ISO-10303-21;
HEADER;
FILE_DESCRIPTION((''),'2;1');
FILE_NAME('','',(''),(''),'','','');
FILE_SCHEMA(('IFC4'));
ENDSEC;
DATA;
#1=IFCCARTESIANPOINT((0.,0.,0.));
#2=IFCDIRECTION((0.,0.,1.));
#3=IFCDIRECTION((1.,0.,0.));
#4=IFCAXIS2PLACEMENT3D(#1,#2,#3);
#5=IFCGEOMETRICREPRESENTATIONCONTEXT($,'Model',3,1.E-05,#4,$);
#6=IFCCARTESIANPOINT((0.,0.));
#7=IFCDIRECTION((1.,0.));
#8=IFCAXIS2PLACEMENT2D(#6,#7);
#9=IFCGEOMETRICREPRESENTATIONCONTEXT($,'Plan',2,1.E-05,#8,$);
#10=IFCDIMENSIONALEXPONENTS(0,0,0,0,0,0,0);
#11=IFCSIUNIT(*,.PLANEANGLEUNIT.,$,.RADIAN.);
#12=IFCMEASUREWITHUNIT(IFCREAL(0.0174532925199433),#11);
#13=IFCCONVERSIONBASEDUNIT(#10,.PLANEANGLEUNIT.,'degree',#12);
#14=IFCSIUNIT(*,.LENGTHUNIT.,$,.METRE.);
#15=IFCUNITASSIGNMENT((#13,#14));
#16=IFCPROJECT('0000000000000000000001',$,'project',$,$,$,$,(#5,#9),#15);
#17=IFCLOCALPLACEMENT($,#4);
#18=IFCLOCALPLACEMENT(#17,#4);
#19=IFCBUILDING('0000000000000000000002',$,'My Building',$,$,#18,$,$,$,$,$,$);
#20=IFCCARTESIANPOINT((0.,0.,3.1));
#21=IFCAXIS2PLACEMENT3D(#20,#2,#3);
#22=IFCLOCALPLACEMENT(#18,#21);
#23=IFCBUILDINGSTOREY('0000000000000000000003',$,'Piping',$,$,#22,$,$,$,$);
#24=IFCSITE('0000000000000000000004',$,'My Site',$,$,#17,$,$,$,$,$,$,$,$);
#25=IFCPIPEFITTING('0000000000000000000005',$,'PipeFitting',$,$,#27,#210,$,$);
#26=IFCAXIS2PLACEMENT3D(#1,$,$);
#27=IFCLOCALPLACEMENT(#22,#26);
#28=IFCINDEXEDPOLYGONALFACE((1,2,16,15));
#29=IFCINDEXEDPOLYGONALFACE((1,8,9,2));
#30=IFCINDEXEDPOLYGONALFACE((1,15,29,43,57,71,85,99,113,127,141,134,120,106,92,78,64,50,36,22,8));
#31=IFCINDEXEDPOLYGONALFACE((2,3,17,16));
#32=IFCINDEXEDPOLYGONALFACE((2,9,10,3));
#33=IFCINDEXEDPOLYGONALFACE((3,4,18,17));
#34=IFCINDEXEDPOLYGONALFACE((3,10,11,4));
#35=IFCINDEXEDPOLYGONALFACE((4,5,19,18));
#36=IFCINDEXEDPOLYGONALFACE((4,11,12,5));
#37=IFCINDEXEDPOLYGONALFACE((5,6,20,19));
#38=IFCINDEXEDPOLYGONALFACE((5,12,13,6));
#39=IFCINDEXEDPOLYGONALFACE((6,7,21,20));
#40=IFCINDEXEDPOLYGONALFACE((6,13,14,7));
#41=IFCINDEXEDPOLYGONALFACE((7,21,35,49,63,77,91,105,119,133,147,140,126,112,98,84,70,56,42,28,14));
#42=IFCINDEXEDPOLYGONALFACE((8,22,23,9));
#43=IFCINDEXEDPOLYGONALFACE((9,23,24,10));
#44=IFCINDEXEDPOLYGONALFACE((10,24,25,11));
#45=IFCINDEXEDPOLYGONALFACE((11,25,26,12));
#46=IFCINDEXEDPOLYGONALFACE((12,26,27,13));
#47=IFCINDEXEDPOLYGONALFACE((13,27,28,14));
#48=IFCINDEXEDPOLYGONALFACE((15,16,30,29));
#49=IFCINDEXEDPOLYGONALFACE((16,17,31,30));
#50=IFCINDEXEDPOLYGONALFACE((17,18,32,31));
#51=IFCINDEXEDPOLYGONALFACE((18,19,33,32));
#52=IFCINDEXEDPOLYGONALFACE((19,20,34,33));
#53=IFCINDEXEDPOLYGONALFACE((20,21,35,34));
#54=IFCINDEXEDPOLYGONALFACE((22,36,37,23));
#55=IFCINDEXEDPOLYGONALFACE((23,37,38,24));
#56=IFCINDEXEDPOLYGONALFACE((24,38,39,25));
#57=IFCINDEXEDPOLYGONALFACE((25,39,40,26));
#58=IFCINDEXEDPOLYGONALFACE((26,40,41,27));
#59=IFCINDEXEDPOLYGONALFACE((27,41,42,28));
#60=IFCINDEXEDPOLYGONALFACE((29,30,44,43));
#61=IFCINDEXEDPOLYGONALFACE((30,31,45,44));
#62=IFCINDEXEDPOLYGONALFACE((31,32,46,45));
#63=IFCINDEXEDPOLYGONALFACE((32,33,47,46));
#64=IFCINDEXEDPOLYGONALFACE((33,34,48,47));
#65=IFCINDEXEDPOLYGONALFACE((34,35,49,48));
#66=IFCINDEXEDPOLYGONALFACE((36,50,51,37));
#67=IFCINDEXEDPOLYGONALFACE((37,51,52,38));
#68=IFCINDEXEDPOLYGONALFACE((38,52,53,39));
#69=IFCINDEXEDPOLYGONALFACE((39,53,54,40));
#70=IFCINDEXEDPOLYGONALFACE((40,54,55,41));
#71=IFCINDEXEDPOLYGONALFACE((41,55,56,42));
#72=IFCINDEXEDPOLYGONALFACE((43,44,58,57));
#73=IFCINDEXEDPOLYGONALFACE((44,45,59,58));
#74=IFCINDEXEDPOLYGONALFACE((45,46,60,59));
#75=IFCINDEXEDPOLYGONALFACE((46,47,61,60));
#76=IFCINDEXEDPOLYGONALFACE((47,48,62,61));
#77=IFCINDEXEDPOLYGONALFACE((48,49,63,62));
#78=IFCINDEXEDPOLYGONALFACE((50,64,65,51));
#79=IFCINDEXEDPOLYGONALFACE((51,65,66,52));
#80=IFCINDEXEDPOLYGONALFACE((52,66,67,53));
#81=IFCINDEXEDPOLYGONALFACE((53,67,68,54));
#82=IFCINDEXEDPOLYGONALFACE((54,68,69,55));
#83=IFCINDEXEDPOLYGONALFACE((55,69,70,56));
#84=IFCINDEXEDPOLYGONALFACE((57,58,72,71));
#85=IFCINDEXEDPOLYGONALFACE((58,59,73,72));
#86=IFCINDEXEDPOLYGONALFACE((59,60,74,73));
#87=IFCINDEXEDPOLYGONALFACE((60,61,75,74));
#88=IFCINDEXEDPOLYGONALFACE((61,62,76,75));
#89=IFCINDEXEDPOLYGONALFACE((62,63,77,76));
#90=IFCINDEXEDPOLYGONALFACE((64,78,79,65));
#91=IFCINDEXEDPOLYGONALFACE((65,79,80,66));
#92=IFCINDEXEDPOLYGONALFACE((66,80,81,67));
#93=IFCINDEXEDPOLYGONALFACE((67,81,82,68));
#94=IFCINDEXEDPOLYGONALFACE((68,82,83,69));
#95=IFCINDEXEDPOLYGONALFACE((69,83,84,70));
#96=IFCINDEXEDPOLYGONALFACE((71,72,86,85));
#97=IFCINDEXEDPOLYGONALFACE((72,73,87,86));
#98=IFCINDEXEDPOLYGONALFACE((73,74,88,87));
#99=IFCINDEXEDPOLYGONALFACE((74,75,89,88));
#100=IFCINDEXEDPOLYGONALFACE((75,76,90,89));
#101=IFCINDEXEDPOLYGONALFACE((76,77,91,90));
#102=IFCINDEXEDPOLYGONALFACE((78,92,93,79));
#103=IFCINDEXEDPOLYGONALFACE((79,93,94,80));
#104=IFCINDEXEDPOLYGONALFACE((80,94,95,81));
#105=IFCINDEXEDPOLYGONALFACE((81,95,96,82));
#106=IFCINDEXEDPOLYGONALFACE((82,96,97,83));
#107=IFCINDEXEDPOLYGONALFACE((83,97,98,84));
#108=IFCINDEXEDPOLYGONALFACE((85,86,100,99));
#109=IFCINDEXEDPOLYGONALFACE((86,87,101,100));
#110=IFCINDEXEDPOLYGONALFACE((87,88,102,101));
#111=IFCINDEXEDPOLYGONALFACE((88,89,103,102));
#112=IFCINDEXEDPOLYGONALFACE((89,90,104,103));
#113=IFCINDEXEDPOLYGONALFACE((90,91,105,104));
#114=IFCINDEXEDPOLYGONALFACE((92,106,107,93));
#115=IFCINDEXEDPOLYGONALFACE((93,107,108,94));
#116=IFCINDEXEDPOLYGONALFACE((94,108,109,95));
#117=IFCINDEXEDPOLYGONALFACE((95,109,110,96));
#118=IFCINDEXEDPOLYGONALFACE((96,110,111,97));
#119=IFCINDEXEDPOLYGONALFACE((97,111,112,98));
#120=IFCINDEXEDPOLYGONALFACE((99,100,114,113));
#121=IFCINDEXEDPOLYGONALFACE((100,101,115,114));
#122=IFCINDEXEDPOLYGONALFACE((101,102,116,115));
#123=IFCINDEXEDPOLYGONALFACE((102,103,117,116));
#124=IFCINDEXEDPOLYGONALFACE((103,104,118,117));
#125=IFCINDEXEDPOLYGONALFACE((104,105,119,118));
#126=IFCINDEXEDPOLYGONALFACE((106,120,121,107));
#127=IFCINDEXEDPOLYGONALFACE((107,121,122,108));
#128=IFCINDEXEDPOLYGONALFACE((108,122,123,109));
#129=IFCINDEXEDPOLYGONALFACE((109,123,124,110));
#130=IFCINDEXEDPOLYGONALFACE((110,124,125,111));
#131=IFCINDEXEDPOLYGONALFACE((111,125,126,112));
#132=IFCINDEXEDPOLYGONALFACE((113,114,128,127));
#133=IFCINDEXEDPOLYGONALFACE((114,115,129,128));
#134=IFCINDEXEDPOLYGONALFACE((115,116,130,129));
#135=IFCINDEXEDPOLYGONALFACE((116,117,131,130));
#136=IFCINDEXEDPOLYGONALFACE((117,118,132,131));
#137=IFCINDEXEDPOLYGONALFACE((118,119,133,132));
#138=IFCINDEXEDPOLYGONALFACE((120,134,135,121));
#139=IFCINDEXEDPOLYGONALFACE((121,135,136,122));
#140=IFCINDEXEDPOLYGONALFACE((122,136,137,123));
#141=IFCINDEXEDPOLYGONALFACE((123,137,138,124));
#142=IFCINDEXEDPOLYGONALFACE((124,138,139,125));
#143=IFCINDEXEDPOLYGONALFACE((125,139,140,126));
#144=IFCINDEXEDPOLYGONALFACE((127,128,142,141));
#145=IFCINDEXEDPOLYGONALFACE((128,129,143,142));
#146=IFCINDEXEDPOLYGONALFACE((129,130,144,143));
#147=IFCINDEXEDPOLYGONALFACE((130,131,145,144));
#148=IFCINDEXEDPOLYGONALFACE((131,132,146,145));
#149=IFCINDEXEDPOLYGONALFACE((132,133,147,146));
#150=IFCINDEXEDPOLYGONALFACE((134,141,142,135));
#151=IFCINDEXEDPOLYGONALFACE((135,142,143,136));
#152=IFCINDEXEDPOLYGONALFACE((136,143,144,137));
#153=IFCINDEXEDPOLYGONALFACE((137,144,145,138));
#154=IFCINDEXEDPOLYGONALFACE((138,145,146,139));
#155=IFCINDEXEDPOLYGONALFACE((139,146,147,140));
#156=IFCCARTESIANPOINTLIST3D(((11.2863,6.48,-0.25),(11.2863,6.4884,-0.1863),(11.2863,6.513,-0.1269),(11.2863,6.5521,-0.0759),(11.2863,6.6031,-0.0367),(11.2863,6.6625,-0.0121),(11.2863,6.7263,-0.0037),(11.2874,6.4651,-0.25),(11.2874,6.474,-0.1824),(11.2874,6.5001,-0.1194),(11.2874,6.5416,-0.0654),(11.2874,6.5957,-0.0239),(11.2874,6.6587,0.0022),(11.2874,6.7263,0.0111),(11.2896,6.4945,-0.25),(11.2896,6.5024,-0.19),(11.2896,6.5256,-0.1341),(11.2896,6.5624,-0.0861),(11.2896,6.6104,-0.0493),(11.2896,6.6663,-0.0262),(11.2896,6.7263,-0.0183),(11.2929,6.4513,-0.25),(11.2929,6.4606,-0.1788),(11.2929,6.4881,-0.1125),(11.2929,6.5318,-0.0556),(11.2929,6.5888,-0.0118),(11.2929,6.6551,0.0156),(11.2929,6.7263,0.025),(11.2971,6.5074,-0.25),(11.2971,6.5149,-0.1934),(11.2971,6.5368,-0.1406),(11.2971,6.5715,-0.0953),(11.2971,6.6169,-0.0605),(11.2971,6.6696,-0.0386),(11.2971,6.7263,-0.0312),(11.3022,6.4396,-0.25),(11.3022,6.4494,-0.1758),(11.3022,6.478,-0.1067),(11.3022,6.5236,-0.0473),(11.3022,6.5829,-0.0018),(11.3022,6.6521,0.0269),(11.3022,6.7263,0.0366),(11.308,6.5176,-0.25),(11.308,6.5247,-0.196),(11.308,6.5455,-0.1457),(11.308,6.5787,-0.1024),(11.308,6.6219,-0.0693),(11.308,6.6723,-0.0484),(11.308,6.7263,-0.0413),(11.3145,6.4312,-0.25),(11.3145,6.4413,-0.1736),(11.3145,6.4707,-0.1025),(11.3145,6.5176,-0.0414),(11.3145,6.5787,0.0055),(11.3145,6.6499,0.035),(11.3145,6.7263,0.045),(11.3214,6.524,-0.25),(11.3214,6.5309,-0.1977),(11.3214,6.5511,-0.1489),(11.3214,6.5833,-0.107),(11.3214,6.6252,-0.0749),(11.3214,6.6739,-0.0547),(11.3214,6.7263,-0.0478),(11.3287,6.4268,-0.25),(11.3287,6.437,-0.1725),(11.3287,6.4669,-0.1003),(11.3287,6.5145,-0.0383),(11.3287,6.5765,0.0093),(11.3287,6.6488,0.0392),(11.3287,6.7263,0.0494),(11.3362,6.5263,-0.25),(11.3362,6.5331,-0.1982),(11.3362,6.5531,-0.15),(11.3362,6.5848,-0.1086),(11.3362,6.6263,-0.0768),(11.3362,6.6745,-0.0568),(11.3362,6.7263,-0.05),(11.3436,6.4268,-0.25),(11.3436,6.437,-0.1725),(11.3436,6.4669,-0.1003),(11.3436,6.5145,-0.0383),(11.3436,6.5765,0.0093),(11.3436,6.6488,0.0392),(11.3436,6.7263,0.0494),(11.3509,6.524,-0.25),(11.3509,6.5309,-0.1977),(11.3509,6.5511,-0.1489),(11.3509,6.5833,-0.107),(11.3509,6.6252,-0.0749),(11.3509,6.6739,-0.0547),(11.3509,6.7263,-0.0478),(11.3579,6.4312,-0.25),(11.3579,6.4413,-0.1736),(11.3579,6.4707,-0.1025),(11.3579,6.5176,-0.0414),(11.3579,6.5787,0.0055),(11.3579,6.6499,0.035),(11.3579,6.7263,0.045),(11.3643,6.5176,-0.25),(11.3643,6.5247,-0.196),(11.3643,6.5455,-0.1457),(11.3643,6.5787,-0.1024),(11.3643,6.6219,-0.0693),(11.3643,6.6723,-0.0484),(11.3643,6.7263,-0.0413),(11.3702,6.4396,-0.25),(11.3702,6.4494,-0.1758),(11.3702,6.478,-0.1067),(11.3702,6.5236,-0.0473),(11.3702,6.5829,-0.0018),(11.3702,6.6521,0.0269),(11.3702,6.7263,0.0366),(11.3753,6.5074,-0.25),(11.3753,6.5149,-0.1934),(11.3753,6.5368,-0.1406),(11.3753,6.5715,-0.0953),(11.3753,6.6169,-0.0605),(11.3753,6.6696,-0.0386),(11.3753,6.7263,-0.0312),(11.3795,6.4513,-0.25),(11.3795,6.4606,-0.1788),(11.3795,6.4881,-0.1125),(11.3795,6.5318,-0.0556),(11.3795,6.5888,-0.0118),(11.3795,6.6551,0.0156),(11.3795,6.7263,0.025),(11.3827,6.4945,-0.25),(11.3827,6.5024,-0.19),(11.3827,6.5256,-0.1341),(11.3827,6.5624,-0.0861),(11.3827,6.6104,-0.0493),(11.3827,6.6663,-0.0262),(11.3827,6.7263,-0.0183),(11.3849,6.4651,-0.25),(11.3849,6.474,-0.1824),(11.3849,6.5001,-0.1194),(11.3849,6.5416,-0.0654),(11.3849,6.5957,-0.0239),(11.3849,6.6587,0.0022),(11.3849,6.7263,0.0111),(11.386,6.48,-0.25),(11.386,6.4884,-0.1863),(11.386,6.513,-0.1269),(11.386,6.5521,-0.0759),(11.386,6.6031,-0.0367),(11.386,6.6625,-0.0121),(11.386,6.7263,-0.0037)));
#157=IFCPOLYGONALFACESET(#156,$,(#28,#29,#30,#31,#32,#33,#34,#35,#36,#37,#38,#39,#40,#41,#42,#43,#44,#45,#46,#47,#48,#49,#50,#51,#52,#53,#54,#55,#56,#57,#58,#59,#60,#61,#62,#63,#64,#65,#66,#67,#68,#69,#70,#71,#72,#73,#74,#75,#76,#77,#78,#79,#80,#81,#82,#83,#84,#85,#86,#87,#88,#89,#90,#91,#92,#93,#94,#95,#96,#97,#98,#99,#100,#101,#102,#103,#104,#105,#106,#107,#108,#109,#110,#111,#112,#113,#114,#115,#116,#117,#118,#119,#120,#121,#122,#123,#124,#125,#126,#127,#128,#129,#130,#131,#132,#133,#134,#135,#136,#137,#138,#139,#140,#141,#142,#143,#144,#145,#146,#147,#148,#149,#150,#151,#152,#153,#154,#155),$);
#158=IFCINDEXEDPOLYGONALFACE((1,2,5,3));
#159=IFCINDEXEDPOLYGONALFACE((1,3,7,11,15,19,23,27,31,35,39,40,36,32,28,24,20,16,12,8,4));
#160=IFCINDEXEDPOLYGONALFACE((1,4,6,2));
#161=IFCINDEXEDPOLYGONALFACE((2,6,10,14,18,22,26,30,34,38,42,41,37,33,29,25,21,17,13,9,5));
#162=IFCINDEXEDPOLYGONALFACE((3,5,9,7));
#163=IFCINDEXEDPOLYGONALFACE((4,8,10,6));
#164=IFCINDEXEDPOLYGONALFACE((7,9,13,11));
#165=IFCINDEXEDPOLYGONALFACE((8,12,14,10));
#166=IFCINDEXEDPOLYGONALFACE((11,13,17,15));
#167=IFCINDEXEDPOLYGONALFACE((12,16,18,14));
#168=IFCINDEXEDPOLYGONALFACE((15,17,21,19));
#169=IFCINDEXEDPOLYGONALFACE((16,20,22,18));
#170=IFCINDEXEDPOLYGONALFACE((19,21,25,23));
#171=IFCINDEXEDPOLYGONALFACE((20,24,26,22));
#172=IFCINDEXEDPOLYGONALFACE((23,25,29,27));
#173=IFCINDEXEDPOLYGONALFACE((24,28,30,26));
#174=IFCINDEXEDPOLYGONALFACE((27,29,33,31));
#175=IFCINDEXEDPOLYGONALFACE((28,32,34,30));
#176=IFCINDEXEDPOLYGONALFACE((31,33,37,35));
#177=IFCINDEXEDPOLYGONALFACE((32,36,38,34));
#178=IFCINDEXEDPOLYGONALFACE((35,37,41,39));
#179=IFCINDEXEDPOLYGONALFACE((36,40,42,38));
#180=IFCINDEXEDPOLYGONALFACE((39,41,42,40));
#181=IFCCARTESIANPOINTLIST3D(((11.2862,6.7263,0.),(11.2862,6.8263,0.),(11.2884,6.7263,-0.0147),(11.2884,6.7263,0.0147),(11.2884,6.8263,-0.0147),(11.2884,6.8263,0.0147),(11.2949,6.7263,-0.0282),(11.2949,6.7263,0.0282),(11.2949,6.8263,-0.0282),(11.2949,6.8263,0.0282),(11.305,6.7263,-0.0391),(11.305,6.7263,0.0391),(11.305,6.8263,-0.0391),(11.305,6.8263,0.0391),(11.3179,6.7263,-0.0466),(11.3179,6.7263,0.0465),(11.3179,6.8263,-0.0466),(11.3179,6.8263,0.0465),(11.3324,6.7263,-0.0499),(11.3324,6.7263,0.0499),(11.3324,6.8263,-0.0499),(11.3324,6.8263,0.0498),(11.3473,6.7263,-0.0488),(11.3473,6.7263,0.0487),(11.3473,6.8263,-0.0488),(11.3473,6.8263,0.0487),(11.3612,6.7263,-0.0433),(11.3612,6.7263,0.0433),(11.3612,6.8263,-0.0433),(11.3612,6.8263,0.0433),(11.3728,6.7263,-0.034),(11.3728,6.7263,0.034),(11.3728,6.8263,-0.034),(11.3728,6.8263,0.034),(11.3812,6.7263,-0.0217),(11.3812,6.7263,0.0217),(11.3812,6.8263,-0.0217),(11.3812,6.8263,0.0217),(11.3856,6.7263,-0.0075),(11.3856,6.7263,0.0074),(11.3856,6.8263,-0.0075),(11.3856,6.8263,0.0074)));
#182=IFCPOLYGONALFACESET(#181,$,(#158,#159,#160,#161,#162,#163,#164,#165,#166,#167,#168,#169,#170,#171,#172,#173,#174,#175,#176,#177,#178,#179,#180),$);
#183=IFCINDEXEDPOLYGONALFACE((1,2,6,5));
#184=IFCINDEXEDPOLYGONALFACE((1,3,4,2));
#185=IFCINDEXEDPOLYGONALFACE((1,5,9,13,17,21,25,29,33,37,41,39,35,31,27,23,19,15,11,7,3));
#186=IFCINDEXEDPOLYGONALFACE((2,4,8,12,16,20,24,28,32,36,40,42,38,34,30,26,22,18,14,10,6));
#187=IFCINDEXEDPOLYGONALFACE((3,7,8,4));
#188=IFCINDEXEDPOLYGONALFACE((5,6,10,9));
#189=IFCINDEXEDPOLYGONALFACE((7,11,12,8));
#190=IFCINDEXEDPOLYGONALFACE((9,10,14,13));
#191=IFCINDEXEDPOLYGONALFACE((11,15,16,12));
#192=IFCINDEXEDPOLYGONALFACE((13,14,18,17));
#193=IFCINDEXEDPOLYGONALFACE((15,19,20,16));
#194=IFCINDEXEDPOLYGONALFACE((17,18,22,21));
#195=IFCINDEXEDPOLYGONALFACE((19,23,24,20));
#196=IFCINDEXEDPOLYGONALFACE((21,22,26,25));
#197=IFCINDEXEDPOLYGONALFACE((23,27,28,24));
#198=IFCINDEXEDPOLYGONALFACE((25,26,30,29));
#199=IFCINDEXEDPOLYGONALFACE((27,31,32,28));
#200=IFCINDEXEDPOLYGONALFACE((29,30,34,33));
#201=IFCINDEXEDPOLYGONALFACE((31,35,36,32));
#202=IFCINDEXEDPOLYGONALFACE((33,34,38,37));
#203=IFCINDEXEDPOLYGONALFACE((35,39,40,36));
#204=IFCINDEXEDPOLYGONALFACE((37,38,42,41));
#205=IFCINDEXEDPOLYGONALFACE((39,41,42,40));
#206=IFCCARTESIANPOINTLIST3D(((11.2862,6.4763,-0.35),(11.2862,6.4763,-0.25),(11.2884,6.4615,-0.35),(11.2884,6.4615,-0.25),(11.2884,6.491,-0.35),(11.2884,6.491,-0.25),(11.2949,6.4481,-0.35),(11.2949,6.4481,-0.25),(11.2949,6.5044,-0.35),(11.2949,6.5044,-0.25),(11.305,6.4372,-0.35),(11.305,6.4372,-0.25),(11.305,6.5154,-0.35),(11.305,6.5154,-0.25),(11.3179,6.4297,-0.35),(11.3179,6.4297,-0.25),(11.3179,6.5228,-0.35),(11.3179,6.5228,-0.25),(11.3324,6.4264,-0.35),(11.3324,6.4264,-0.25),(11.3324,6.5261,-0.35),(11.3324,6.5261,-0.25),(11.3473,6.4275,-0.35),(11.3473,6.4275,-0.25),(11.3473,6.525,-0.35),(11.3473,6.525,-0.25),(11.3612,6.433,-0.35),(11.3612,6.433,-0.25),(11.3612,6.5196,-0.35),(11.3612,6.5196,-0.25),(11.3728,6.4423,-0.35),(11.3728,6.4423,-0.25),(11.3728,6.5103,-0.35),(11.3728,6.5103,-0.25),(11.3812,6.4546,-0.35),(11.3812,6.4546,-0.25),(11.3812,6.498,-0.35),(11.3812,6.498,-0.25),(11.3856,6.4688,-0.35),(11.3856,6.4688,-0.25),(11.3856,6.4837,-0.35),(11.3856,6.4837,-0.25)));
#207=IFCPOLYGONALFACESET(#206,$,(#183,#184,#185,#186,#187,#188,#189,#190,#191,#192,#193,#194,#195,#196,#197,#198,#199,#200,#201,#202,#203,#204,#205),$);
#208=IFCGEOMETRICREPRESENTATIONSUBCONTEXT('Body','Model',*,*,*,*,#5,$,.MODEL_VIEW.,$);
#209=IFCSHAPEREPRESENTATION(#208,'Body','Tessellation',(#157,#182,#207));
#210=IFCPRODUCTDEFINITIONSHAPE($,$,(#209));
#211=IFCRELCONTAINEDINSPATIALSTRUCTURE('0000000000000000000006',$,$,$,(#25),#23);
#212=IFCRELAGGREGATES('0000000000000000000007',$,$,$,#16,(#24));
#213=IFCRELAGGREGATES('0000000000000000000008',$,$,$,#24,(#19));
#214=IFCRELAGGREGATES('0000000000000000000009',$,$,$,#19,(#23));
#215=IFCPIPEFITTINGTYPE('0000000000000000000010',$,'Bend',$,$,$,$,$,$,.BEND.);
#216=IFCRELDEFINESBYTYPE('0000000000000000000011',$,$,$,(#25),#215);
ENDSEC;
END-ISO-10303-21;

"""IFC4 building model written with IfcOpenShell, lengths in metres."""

from ifc_helpers import new_model, entity, si_unit, converted_unit, frame, origin_with_axes, origin_2d_with_axis, place, context, subcontext, project, spatial, circle, extrude, source, transform, mapped, type_object, type_shapes, element, save


model = new_model("IFC4")

# Units and contexts
model_context = context("Model", 3, precision=1e-05, world=origin_with_axes())
plan_context = context("Plan", 2, precision=1e-05, world=origin_2d_with_axis())
body_context = subcontext(model_context, "Body", "Model", "MODEL_VIEW")
ifc_project = project(units=[converted_unit("PLANEANGLEUNIT", "degree", entity("IfcReal", 0.0174532925199433), si_unit("PLANEANGLEUNIT", "RADIAN"), dimensions=[0, 0, 0, 0, 0, 0, 0]), si_unit("LENGTHUNIT", "METRE")], contexts=[model_context, plan_context])

# Site, building, storey
site_placement = place(None, origin_with_axes())
site = spatial("IfcSite", under=ifc_project, at=site_placement, Name="My Site")
building_placement = place(site_placement, origin_with_axes())
building = spatial("IfcBuilding", under=site, at=building_placement, Name="My Building")
storey_placement = place(building_placement, frame((0.0, 0.0, 3.1), z_axis=(0.0, 0.0, 1.0), x_axis=(1.0, 0.0, 0.0)))
storey = spatial("IfcBuildingStorey", under=building, at=storey_placement, Name="Piping")

# Pipe fitting
pipe_fitting_type_1 = type_object("IfcPipeFittingType", Name="Bend", PredefinedType="BEND")
shared_shape_1 = source(origin_with_axes(), body_context, "Body", "SolidModel", [
    entity("IfcSweptDiskSolid", entity("IfcIndexedPolyCurve", entity("IfcCartesianPointList3D", [[0.0, 0.0, -0.1], [0.0, -0.0732, -0.2768], [0.0, -0.25, -0.35]]), [entity("IfcArcIndex", [1, 2, 3])]), 0.05),
    extrude(circle(Radius=0.05), origin_with_axes(), (0.0, 0.0, -1.0), 0.1),
    extrude(circle(Radius=0.05), frame((0.0, -0.25, -0.35), z_axis=(0.0, -1.0, 0.000022), x_axis=(1.0, 0.0, 0.0)), (0.0, 0.0, 1.0), 0.1),
])
type_shapes(pipe_fitting_type_1, [shared_shape_1])
for number, where, z_axis, x_axis, name in (
    (1, (11.3362, 6.8263, 0.0), (0.0, 1.0, -0.000022), (-1.0, 0.0, 0.0), "PipeFitting"),
):
    element("IfcPipeFitting", number, at=place(storey_placement, frame(where, z_axis=z_axis, x_axis=x_axis)), inside=storey, type_object=pipe_fitting_type_1, Name=name, context=body_context, shape_type="MappedRepresentation", body=[
        mapped(shared_shape_1, transform((0.0, 0.0, 0.0), x_axis=(1.0, 0.0, 0.0), y_axis=(0.0, 1.0, 0.0), z_axis=(0.0, 0.0, 1.0), scale=1.0)),
    ])

save(model, "model.ifc")
